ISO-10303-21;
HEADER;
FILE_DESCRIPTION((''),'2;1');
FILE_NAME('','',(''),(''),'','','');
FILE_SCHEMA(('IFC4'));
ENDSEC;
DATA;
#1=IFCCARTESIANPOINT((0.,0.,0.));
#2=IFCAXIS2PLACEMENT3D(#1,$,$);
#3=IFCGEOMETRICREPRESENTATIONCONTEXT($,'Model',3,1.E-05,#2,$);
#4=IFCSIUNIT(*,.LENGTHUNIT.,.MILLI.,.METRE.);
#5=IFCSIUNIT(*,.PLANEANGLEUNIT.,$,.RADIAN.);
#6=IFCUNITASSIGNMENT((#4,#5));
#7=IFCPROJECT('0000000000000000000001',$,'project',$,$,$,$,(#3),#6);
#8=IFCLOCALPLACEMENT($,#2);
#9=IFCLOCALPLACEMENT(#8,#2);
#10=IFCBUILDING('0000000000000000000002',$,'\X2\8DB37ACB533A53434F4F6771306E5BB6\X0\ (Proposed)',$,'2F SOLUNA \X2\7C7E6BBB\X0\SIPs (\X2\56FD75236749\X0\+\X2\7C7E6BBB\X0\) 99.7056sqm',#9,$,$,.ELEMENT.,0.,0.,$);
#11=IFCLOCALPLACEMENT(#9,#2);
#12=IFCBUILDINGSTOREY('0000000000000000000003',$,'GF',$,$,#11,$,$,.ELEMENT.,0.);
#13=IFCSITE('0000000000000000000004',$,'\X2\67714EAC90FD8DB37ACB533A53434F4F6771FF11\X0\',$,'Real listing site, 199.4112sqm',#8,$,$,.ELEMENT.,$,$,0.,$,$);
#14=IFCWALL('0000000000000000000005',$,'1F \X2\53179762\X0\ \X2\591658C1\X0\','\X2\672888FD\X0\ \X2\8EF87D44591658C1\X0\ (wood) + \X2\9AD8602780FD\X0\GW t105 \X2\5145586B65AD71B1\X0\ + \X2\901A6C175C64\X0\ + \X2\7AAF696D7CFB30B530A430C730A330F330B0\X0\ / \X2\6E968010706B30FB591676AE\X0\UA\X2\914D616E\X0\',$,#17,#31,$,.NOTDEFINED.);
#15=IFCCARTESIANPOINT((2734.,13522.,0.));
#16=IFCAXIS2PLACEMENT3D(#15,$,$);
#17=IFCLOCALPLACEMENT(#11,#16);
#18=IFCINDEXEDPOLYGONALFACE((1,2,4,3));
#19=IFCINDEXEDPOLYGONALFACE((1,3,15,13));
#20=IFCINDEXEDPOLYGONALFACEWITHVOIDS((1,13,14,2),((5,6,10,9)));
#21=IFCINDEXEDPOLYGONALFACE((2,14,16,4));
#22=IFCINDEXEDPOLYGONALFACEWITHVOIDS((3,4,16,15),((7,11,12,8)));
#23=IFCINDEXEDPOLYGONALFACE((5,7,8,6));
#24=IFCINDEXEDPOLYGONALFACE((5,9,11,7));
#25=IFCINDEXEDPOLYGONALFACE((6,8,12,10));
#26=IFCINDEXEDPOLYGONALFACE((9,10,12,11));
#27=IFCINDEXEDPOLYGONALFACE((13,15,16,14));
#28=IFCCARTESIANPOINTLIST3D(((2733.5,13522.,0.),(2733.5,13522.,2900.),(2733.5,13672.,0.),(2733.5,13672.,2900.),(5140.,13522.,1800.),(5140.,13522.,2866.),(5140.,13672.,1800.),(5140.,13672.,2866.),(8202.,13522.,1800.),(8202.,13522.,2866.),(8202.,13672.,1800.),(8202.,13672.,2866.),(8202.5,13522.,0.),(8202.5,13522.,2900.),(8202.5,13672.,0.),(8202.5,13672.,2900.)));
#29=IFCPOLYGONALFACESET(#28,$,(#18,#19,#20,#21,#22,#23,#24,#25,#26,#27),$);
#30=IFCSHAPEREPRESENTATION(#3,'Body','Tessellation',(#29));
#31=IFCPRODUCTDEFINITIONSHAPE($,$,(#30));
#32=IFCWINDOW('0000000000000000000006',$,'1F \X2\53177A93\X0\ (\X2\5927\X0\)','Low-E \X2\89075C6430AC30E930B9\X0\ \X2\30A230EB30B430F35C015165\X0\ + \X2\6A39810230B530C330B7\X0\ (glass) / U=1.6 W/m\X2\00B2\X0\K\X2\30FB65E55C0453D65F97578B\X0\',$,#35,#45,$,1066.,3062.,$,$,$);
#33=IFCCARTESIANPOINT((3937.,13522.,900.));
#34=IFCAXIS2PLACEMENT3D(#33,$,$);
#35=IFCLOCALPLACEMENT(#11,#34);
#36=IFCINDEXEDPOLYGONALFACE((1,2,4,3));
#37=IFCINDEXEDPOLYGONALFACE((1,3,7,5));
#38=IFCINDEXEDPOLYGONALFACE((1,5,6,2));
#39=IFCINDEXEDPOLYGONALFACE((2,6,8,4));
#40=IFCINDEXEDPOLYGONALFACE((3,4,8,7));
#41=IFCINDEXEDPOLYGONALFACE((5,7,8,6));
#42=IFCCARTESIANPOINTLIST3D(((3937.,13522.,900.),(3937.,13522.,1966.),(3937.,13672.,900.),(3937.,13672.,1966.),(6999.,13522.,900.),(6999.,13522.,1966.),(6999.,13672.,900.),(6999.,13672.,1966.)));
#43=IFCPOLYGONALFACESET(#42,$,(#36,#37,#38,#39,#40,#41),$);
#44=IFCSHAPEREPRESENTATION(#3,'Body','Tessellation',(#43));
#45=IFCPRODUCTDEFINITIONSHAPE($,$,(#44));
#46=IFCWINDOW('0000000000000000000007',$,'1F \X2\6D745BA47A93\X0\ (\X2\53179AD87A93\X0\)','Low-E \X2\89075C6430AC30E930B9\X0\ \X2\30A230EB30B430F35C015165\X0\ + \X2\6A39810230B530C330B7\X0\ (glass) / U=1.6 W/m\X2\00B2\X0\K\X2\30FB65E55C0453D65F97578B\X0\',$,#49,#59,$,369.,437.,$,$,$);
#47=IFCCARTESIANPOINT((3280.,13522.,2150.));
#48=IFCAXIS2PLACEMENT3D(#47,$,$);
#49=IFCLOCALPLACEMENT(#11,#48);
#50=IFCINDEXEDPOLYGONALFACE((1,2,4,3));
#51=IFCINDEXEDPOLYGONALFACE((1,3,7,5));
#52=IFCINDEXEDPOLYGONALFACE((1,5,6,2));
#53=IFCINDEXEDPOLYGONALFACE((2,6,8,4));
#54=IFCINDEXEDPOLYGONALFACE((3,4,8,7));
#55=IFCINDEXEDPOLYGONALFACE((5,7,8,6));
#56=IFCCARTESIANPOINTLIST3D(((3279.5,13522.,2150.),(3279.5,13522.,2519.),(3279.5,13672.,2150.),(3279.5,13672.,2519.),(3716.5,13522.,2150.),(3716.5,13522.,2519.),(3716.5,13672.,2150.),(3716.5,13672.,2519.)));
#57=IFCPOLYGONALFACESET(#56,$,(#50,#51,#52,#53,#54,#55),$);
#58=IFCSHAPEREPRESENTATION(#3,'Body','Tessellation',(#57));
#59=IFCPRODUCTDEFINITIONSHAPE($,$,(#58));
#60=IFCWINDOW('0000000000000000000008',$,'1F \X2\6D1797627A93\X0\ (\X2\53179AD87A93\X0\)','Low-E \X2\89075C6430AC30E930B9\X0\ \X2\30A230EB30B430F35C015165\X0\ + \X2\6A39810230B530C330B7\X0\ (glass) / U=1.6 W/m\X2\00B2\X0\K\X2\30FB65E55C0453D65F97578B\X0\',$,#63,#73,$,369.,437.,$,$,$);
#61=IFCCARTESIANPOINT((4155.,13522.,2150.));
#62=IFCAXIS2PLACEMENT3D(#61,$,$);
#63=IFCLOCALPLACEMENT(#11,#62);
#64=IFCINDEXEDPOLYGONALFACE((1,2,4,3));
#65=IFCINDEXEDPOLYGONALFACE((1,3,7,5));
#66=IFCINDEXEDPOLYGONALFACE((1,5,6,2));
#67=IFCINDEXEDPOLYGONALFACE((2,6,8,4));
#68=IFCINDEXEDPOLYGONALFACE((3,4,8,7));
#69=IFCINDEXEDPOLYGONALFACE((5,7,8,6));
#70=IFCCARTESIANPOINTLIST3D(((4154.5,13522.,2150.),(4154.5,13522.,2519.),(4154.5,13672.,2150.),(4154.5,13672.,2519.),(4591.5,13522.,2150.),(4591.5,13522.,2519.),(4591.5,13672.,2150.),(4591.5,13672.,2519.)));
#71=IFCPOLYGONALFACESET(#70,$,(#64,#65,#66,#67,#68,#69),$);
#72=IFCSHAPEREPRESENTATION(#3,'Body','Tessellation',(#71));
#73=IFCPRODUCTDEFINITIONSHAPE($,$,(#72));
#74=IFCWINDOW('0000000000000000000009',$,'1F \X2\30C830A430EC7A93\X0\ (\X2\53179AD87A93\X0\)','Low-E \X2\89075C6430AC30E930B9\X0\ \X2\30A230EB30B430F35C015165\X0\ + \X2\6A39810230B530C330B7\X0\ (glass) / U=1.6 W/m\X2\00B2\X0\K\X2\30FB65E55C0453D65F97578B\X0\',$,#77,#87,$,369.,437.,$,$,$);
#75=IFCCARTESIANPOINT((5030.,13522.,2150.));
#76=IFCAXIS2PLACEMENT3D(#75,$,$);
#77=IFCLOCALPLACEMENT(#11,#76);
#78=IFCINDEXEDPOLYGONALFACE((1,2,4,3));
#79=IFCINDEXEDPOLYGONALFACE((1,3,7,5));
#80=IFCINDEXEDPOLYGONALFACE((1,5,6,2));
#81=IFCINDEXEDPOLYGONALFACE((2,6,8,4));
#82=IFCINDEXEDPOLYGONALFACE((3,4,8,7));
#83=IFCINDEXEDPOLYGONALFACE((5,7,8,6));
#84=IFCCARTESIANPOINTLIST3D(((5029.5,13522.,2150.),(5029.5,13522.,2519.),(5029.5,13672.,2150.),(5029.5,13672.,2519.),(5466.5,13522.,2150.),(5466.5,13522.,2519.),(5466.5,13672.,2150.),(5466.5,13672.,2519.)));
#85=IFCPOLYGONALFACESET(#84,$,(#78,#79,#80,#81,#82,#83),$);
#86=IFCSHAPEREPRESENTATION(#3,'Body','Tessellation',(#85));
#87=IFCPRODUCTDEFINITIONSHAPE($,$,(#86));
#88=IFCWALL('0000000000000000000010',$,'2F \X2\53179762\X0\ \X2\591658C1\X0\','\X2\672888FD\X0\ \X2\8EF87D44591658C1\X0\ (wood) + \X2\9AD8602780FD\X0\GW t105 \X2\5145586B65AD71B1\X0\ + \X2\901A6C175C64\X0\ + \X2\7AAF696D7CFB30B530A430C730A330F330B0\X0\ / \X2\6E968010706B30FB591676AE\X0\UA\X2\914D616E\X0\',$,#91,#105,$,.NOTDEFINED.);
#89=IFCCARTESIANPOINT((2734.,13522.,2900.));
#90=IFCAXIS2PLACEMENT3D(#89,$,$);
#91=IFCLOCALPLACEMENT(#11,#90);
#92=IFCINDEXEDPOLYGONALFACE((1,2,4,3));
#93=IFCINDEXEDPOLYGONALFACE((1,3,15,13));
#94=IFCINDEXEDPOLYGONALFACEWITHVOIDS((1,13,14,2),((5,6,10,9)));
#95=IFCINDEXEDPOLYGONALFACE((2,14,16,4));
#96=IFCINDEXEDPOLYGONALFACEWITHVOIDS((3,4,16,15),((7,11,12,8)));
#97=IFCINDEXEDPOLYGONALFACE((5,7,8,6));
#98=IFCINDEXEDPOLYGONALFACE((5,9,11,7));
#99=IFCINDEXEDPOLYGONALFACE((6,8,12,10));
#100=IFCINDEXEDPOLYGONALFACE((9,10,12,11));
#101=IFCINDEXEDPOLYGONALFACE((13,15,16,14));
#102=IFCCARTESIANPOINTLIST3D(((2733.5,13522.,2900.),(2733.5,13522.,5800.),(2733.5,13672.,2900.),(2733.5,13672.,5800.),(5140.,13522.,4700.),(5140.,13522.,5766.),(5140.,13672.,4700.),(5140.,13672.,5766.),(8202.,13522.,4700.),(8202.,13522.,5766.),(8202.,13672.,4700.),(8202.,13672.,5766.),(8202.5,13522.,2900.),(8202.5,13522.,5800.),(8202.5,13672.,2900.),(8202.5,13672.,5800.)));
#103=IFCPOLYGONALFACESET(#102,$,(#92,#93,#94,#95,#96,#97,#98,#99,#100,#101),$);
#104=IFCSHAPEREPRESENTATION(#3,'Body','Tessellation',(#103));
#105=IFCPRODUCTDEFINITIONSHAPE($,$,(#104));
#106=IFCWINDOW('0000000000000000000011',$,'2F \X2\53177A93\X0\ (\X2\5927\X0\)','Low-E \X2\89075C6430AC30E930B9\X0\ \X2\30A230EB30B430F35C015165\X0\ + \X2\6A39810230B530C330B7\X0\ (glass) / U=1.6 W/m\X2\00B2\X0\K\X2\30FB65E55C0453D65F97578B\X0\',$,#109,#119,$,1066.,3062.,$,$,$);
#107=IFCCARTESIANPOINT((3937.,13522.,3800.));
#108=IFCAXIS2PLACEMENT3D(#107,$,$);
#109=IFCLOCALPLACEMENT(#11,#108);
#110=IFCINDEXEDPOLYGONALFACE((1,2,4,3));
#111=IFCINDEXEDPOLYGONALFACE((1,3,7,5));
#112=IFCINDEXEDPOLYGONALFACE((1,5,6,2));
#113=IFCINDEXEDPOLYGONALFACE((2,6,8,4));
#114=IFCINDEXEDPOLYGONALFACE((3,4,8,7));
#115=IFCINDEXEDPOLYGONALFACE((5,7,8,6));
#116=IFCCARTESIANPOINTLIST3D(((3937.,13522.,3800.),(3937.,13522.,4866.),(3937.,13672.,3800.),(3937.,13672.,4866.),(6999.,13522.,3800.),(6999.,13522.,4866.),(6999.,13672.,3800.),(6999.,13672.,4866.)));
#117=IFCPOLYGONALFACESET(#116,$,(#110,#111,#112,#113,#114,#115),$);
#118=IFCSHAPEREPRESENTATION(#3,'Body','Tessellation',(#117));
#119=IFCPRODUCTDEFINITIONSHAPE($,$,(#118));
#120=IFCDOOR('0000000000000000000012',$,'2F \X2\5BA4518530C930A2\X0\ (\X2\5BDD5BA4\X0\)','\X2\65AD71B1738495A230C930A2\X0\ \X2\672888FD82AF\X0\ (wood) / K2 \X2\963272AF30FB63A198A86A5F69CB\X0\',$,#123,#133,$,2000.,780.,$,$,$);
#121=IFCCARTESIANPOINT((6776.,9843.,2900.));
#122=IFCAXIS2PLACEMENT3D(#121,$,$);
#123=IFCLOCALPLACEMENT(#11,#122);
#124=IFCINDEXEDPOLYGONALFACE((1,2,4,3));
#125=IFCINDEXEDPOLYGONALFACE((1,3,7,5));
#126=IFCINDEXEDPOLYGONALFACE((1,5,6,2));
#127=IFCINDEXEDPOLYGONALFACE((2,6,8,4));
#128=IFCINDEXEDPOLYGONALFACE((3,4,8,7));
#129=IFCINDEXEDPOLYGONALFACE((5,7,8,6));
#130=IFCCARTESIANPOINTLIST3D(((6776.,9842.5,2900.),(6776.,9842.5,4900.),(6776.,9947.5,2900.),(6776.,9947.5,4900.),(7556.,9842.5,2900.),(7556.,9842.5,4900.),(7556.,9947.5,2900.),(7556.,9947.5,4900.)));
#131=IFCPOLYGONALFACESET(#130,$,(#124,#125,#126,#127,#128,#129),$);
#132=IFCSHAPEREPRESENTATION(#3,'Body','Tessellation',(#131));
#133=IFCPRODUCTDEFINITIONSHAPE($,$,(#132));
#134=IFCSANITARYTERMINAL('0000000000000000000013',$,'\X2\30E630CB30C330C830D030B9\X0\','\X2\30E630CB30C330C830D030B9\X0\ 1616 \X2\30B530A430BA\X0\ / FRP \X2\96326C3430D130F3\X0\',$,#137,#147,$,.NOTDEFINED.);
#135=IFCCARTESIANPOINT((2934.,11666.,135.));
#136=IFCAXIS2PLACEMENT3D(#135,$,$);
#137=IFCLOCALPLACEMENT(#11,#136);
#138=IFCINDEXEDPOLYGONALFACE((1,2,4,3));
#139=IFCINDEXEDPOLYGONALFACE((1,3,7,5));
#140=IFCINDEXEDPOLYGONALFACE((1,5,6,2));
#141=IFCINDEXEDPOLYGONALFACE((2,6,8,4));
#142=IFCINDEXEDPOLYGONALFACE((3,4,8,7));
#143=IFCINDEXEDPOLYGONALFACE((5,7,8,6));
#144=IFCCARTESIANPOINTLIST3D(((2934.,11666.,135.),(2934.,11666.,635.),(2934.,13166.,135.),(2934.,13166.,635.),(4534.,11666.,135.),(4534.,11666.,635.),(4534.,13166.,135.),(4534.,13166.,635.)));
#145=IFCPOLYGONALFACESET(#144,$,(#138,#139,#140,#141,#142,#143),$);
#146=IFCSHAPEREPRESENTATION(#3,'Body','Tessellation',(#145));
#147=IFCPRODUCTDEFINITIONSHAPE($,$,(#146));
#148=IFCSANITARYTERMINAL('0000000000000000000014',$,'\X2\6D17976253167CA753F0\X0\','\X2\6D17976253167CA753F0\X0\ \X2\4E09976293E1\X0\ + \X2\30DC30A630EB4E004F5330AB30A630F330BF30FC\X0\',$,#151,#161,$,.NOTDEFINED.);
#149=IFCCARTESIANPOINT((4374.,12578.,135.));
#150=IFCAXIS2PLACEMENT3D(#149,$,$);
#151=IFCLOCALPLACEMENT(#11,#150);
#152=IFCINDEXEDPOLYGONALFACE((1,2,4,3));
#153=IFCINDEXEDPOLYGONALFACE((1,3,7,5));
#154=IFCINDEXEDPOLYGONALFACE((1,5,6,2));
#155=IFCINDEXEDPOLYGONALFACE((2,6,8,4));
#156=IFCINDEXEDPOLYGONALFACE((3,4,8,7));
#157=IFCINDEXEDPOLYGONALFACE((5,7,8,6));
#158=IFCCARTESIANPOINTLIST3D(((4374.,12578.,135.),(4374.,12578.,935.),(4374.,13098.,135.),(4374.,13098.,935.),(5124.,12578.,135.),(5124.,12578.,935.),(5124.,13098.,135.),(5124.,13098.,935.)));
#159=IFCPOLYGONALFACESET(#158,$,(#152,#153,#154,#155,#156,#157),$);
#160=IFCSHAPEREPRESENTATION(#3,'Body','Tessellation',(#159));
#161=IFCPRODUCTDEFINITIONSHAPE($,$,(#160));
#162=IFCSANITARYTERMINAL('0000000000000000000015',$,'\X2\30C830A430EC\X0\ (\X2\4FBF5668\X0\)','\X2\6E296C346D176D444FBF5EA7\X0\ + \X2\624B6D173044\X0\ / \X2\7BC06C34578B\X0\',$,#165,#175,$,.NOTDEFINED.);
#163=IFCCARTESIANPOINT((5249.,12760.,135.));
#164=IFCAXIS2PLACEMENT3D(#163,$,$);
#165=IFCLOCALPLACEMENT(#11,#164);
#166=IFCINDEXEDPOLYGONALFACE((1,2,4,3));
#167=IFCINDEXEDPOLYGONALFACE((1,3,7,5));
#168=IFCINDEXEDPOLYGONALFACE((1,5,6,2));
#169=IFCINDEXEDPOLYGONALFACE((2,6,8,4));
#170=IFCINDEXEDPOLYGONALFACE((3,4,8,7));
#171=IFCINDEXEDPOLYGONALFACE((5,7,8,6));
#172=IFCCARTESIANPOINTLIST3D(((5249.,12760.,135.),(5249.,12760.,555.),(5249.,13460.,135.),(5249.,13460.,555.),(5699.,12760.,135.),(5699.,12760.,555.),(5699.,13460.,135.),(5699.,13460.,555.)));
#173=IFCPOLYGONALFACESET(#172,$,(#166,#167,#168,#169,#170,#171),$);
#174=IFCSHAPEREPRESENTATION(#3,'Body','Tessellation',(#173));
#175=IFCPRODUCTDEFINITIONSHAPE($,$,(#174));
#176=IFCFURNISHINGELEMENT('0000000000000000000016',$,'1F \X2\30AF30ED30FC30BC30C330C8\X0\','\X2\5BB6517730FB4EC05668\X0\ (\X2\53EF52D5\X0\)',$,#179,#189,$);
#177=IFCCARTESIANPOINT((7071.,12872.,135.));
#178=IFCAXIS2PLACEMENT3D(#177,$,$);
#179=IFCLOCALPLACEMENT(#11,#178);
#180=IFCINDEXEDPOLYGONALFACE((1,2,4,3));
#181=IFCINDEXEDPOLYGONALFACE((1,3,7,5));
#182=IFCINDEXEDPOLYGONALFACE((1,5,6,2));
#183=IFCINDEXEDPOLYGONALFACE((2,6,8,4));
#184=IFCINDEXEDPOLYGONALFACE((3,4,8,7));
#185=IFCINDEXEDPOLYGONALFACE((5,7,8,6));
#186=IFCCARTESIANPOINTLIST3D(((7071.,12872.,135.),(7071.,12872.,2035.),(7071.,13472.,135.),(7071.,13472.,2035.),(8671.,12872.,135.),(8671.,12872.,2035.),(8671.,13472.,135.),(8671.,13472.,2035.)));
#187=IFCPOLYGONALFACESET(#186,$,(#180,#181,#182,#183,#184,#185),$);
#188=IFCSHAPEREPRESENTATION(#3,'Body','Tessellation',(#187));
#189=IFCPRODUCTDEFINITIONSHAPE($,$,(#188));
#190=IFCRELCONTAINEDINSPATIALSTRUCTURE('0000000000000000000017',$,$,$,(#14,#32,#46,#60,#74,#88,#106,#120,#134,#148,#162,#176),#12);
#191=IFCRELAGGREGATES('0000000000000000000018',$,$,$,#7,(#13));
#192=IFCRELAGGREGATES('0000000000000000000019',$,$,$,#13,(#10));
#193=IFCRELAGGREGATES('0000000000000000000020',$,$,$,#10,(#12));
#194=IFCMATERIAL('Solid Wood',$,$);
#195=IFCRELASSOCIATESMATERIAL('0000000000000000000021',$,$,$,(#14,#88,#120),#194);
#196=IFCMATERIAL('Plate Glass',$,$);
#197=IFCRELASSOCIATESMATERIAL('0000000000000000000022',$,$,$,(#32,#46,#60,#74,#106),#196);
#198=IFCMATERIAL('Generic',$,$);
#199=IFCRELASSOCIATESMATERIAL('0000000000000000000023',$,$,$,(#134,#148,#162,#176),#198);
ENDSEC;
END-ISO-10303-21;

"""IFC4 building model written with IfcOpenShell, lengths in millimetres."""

from ifc_helpers import new_model, si_unit, frame, frame_2d, origin, place, context, project, spatial, rectangle, extrude, material, element, fill, save


model = new_model("IFC4")

# Units and contexts
model_context = context("Model", 3, precision=1e-05, world=origin())
ifc_project = project(units=[si_unit("LENGTHUNIT", "METRE", prefix="MILLI"), si_unit("PLANEANGLEUNIT", "RADIAN")], contexts=[model_context])

# Site, building, storey
site_placement = place(None, origin())
site = spatial("IfcSite", under=ifc_project, at=site_placement, Name="東京都足立区千住東１", ObjectType="Real listing site, 199.4112sqm", CompositionType="ELEMENT", RefElevation=0.0)
building_placement = place(site_placement, origin())
building = spatial("IfcBuilding", under=site, at=building_placement, Name="足立区千住東の家 (Proposed)", ObjectType="2F SOLUNA 籾殻SIPs (国産杉+籾殻) 99.7056sqm", CompositionType="ELEMENT", ElevationOfRefHeight=0.0, ElevationOfTerrain=0.0)
storey_placement = place(building_placement, origin())
storey = spatial("IfcBuildingStorey", under=building, at=storey_placement, Name="GF", CompositionType="ELEMENT", Elevation=0.0)

# Wall, openings, windows
ifc_material_1 = material(Name="Solid Wood")
wall_1_placement = place(storey_placement, frame((2734.0, 13522.0, 0.0)))
wall_1 = element("IfcWall", 1, at=wall_1_placement, inside=storey, material=ifc_material_1, Name="1F 北面 外壁", Description="木製 軸組外壁 (wood) + 高性能GW t105 充填断熱 + 通気層 + 窯業系サイディング / 準耐火・外皮UA配慮", PredefinedType="NOTDEFINED", context=model_context, shape_type="SweptSolid", body=[
    extrude(rectangle(XDim=5469.0, YDim=150.0, at=frame_2d((2734.0, 75.0))), frame((2734.0, 13522.0, 0.0)), (0.0, 0.0, 1.0), 2900.0),
])
opening_1_placement = place(storey_placement, frame((3937.0, 13522.0, 900.0)))
opening_1 = element("IfcOpeningElement", 2, at=opening_1_placement, cuts=wall_1, PredefinedType="NOTDEFINED", context=model_context, shape_type="SweptSolid", body=[
    extrude(rectangle(XDim=3062.0, YDim=150.0, at=frame_2d((1531.0, 75.0))), frame((3937.0, 13522.0, 900.0)), (0.0, 0.0, 1.0), 1066.0),
])
opening_2_placement = place(storey_placement, frame((3280.0, 13522.0, 2150.0)))
opening_2 = element("IfcOpeningElement", 3, at=opening_2_placement, cuts=wall_1, PredefinedType="NOTDEFINED", context=model_context, shape_type="SweptSolid", body=[
    extrude(rectangle(XDim=437.0, YDim=150.0, at=frame_2d((218.0, 75.0))), frame((3280.0, 13522.0, 2150.0)), (0.0, 0.0, 1.0), 369.0),
])
opening_3_placement = place(storey_placement, frame((4155.0, 13522.0, 2150.0)))
opening_3 = element("IfcOpeningElement", 4, at=opening_3_placement, cuts=wall_1, PredefinedType="NOTDEFINED", context=model_context, shape_type="SweptSolid", body=[
    extrude(rectangle(XDim=437.0, YDim=150.0, at=frame_2d((218.0, 75.0))), frame((4155.0, 13522.0, 2150.0)), (0.0, 0.0, 1.0), 369.0),
])
opening_4_placement = place(storey_placement, frame((5030.0, 13522.0, 2150.0)))
opening_4 = element("IfcOpeningElement", 5, at=opening_4_placement, cuts=wall_1, PredefinedType="NOTDEFINED", context=model_context, shape_type="SweptSolid", body=[
    extrude(rectangle(XDim=437.0, YDim=150.0, at=frame_2d((218.0, 75.0))), frame((5030.0, 13522.0, 2150.0)), (0.0, 0.0, 1.0), 369.0),
])
ifc_material_2 = material(Name="Plate Glass")
window_1_placement = place(storey_placement, frame((3937.0, 13522.0, 900.0)))
window_1 = element("IfcWindow", 6, at=window_1_placement, inside=storey, material=ifc_material_2, Name="1F 北窓 (大)", Description="Low-E 複層ガラス アルゴン封入 + 樹脂サッシ (glass) / U=1.6 W/m²K・日射取得型", OverallHeight=1066.0, OverallWidth=3062.0, context=model_context, shape_type="SweptSolid", body=[
    extrude(rectangle(XDim=3062.0, YDim=150.0, at=frame_2d((1531.0, 75.0))), frame((3937.0, 13522.0, 900.0)), (0.0, 0.0, 1.0), 1066.0),
])
fill(opening_1, window_1)
window_2_placement = place(storey_placement, frame((3280.0, 13522.0, 2150.0)))
window_2 = element("IfcWindow", 7, at=window_2_placement, inside=storey, material=ifc_material_2, Name="1F 浴室窓 (北高窓)", Description="Low-E 複層ガラス アルゴン封入 + 樹脂サッシ (glass) / U=1.6 W/m²K・日射取得型", OverallHeight=369.0, OverallWidth=437.0, context=model_context, shape_type="SweptSolid", body=[
    extrude(rectangle(XDim=437.0, YDim=150.0, at=frame_2d((218.0, 75.0))), frame((3280.0, 13522.0, 2150.0)), (0.0, 0.0, 1.0), 369.0),
])
fill(opening_2, window_2)
window_3_placement = place(storey_placement, frame((4155.0, 13522.0, 2150.0)))
window_3 = element("IfcWindow", 8, at=window_3_placement, inside=storey, material=ifc_material_2, Name="1F 洗面窓 (北高窓)", Description="Low-E 複層ガラス アルゴン封入 + 樹脂サッシ (glass) / U=1.6 W/m²K・日射取得型", OverallHeight=369.0, OverallWidth=437.0, context=model_context, shape_type="SweptSolid", body=[
    extrude(rectangle(XDim=437.0, YDim=150.0, at=frame_2d((218.0, 75.0))), frame((4155.0, 13522.0, 2150.0)), (0.0, 0.0, 1.0), 369.0),
])
fill(opening_3, window_3)
window_4_placement = place(storey_placement, frame((5030.0, 13522.0, 2150.0)))
window_4 = element("IfcWindow", 9, at=window_4_placement, inside=storey, material=ifc_material_2, Name="1F トイレ窓 (北高窓)", Description="Low-E 複層ガラス アルゴン封入 + 樹脂サッシ (glass) / U=1.6 W/m²K・日射取得型", OverallHeight=369.0, OverallWidth=437.0, context=model_context, shape_type="SweptSolid", body=[
    extrude(rectangle(XDim=437.0, YDim=150.0, at=frame_2d((218.0, 75.0))), frame((5030.0, 13522.0, 2150.0)), (0.0, 0.0, 1.0), 369.0),
])
fill(opening_4, window_4)

# Wall, opening, window
wall_2_placement = place(storey_placement, frame((2734.0, 13522.0, 2900.0)))
wall_2 = element("IfcWall", 10, at=wall_2_placement, inside=storey, material=ifc_material_1, Name="2F 北面 外壁", Description="木製 軸組外壁 (wood) + 高性能GW t105 充填断熱 + 通気層 + 窯業系サイディング / 準耐火・外皮UA配慮", PredefinedType="NOTDEFINED", context=model_context, shape_type="SweptSolid", body=[
    extrude(rectangle(XDim=5469.0, YDim=150.0, at=frame_2d((2734.0, 75.0))), frame((2734.0, 13522.0, 2900.0)), (0.0, 0.0, 1.0), 2900.0),
])
opening_5_placement = place(storey_placement, frame((3937.0, 13522.0, 3800.0)))
opening_5 = element("IfcOpeningElement", 11, at=opening_5_placement, cuts=wall_2, PredefinedType="NOTDEFINED", context=model_context, shape_type="SweptSolid", body=[
    extrude(rectangle(XDim=3062.0, YDim=150.0, at=frame_2d((1531.0, 75.0))), frame((3937.0, 13522.0, 3800.0)), (0.0, 0.0, 1.0), 1066.0),
])
window_5_placement = place(storey_placement, frame((3937.0, 13522.0, 3800.0)))
window_5 = element("IfcWindow", 12, at=window_5_placement, inside=storey, material=ifc_material_2, Name="2F 北窓 (大)", Description="Low-E 複層ガラス アルゴン封入 + 樹脂サッシ (glass) / U=1.6 W/m²K・日射取得型", OverallHeight=1066.0, OverallWidth=3062.0, context=model_context, shape_type="SweptSolid", body=[
    extrude(rectangle(XDim=3062.0, YDim=150.0, at=frame_2d((1531.0, 75.0))), frame((3937.0, 13522.0, 3800.0)), (0.0, 0.0, 1.0), 1066.0),
])
fill(opening_5, window_5)

# Door
door_1_placement = place(storey_placement, frame((6776.0, 9843.0, 2900.0)))
element("IfcDoor", 13, at=door_1_placement, inside=storey, material=ifc_material_1, Name="2F 室内ドア (寝室)", Description="断熱玄関ドア 木製芯 (wood) / K2 防犯・採風機構", OverallHeight=2000.0, OverallWidth=780.0, context=model_context, shape_type="SweptSolid", body=[
    extrude(rectangle(XDim=780.0, YDim=105.0, at=frame_2d((390.0, 52.0))), frame((6776.0, 9843.0, 2900.0)), (0.0, 0.0, 1.0), 2000.0),
])

# Sanitary terminals
ifc_material_3 = material(Name="Generic")
sanitary_terminal_1_placement = place(storey_placement, frame((2934.0, 11666.0, 135.0)))
element("IfcSanitaryTerminal", 14, at=sanitary_terminal_1_placement, inside=storey, material=ifc_material_3, Name="ユニットバス", Description="ユニットバス 1616 サイズ / FRP 防水パン", PredefinedType="NOTDEFINED", context=model_context, shape_type="SweptSolid", body=[
    extrude(rectangle(XDim=1600.0, YDim=1500.0, at=frame_2d((800.0, 750.0))), frame((2934.0, 11666.0, 135.0)), (0.0, 0.0, 1.0), 500.0),
])
sanitary_terminal_2_placement = place(storey_placement, frame((4374.0, 12578.0, 135.0)))
element("IfcSanitaryTerminal", 15, at=sanitary_terminal_2_placement, inside=storey, material=ifc_material_3, Name="洗面化粧台", Description="洗面化粧台 三面鏡 + ボウル一体カウンター", PredefinedType="NOTDEFINED", context=model_context, shape_type="SweptSolid", body=[
    extrude(rectangle(XDim=750.0, YDim=520.0, at=frame_2d((375.0, 260.0))), frame((4374.0, 12578.0, 135.0)), (0.0, 0.0, 1.0), 800.0),
])
sanitary_terminal_3_placement = place(storey_placement, frame((5249.0, 12760.0, 135.0)))
element("IfcSanitaryTerminal", 16, at=sanitary_terminal_3_placement, inside=storey, material=ifc_material_3, Name="トイレ (便器)", Description="温水洗浄便座 + 手洗い / 節水型", PredefinedType="NOTDEFINED", context=model_context, shape_type="SweptSolid", body=[
    extrude(rectangle(XDim=450.0, YDim=700.0, at=frame_2d((225.0, 350.0))), frame((5249.0, 12760.0, 135.0)), (0.0, 0.0, 1.0), 420.0),
])

# Furnishing element
furnishing_1_placement = place(storey_placement, frame((7071.0, 12872.0, 135.0)))
element("IfcFurnishingElement", 17, at=furnishing_1_placement, inside=storey, material=ifc_material_3, Name="1F クローゼット", Description="家具・什器 (可動)", context=model_context, shape_type="SweptSolid", body=[
    extrude(rectangle(XDim=1600.0, YDim=600.0, at=frame_2d((800.0, 300.0))), frame((7071.0, 12872.0, 135.0)), (0.0, 0.0, 1.0), 1900.0),
])

save(model, "model.ifc")
